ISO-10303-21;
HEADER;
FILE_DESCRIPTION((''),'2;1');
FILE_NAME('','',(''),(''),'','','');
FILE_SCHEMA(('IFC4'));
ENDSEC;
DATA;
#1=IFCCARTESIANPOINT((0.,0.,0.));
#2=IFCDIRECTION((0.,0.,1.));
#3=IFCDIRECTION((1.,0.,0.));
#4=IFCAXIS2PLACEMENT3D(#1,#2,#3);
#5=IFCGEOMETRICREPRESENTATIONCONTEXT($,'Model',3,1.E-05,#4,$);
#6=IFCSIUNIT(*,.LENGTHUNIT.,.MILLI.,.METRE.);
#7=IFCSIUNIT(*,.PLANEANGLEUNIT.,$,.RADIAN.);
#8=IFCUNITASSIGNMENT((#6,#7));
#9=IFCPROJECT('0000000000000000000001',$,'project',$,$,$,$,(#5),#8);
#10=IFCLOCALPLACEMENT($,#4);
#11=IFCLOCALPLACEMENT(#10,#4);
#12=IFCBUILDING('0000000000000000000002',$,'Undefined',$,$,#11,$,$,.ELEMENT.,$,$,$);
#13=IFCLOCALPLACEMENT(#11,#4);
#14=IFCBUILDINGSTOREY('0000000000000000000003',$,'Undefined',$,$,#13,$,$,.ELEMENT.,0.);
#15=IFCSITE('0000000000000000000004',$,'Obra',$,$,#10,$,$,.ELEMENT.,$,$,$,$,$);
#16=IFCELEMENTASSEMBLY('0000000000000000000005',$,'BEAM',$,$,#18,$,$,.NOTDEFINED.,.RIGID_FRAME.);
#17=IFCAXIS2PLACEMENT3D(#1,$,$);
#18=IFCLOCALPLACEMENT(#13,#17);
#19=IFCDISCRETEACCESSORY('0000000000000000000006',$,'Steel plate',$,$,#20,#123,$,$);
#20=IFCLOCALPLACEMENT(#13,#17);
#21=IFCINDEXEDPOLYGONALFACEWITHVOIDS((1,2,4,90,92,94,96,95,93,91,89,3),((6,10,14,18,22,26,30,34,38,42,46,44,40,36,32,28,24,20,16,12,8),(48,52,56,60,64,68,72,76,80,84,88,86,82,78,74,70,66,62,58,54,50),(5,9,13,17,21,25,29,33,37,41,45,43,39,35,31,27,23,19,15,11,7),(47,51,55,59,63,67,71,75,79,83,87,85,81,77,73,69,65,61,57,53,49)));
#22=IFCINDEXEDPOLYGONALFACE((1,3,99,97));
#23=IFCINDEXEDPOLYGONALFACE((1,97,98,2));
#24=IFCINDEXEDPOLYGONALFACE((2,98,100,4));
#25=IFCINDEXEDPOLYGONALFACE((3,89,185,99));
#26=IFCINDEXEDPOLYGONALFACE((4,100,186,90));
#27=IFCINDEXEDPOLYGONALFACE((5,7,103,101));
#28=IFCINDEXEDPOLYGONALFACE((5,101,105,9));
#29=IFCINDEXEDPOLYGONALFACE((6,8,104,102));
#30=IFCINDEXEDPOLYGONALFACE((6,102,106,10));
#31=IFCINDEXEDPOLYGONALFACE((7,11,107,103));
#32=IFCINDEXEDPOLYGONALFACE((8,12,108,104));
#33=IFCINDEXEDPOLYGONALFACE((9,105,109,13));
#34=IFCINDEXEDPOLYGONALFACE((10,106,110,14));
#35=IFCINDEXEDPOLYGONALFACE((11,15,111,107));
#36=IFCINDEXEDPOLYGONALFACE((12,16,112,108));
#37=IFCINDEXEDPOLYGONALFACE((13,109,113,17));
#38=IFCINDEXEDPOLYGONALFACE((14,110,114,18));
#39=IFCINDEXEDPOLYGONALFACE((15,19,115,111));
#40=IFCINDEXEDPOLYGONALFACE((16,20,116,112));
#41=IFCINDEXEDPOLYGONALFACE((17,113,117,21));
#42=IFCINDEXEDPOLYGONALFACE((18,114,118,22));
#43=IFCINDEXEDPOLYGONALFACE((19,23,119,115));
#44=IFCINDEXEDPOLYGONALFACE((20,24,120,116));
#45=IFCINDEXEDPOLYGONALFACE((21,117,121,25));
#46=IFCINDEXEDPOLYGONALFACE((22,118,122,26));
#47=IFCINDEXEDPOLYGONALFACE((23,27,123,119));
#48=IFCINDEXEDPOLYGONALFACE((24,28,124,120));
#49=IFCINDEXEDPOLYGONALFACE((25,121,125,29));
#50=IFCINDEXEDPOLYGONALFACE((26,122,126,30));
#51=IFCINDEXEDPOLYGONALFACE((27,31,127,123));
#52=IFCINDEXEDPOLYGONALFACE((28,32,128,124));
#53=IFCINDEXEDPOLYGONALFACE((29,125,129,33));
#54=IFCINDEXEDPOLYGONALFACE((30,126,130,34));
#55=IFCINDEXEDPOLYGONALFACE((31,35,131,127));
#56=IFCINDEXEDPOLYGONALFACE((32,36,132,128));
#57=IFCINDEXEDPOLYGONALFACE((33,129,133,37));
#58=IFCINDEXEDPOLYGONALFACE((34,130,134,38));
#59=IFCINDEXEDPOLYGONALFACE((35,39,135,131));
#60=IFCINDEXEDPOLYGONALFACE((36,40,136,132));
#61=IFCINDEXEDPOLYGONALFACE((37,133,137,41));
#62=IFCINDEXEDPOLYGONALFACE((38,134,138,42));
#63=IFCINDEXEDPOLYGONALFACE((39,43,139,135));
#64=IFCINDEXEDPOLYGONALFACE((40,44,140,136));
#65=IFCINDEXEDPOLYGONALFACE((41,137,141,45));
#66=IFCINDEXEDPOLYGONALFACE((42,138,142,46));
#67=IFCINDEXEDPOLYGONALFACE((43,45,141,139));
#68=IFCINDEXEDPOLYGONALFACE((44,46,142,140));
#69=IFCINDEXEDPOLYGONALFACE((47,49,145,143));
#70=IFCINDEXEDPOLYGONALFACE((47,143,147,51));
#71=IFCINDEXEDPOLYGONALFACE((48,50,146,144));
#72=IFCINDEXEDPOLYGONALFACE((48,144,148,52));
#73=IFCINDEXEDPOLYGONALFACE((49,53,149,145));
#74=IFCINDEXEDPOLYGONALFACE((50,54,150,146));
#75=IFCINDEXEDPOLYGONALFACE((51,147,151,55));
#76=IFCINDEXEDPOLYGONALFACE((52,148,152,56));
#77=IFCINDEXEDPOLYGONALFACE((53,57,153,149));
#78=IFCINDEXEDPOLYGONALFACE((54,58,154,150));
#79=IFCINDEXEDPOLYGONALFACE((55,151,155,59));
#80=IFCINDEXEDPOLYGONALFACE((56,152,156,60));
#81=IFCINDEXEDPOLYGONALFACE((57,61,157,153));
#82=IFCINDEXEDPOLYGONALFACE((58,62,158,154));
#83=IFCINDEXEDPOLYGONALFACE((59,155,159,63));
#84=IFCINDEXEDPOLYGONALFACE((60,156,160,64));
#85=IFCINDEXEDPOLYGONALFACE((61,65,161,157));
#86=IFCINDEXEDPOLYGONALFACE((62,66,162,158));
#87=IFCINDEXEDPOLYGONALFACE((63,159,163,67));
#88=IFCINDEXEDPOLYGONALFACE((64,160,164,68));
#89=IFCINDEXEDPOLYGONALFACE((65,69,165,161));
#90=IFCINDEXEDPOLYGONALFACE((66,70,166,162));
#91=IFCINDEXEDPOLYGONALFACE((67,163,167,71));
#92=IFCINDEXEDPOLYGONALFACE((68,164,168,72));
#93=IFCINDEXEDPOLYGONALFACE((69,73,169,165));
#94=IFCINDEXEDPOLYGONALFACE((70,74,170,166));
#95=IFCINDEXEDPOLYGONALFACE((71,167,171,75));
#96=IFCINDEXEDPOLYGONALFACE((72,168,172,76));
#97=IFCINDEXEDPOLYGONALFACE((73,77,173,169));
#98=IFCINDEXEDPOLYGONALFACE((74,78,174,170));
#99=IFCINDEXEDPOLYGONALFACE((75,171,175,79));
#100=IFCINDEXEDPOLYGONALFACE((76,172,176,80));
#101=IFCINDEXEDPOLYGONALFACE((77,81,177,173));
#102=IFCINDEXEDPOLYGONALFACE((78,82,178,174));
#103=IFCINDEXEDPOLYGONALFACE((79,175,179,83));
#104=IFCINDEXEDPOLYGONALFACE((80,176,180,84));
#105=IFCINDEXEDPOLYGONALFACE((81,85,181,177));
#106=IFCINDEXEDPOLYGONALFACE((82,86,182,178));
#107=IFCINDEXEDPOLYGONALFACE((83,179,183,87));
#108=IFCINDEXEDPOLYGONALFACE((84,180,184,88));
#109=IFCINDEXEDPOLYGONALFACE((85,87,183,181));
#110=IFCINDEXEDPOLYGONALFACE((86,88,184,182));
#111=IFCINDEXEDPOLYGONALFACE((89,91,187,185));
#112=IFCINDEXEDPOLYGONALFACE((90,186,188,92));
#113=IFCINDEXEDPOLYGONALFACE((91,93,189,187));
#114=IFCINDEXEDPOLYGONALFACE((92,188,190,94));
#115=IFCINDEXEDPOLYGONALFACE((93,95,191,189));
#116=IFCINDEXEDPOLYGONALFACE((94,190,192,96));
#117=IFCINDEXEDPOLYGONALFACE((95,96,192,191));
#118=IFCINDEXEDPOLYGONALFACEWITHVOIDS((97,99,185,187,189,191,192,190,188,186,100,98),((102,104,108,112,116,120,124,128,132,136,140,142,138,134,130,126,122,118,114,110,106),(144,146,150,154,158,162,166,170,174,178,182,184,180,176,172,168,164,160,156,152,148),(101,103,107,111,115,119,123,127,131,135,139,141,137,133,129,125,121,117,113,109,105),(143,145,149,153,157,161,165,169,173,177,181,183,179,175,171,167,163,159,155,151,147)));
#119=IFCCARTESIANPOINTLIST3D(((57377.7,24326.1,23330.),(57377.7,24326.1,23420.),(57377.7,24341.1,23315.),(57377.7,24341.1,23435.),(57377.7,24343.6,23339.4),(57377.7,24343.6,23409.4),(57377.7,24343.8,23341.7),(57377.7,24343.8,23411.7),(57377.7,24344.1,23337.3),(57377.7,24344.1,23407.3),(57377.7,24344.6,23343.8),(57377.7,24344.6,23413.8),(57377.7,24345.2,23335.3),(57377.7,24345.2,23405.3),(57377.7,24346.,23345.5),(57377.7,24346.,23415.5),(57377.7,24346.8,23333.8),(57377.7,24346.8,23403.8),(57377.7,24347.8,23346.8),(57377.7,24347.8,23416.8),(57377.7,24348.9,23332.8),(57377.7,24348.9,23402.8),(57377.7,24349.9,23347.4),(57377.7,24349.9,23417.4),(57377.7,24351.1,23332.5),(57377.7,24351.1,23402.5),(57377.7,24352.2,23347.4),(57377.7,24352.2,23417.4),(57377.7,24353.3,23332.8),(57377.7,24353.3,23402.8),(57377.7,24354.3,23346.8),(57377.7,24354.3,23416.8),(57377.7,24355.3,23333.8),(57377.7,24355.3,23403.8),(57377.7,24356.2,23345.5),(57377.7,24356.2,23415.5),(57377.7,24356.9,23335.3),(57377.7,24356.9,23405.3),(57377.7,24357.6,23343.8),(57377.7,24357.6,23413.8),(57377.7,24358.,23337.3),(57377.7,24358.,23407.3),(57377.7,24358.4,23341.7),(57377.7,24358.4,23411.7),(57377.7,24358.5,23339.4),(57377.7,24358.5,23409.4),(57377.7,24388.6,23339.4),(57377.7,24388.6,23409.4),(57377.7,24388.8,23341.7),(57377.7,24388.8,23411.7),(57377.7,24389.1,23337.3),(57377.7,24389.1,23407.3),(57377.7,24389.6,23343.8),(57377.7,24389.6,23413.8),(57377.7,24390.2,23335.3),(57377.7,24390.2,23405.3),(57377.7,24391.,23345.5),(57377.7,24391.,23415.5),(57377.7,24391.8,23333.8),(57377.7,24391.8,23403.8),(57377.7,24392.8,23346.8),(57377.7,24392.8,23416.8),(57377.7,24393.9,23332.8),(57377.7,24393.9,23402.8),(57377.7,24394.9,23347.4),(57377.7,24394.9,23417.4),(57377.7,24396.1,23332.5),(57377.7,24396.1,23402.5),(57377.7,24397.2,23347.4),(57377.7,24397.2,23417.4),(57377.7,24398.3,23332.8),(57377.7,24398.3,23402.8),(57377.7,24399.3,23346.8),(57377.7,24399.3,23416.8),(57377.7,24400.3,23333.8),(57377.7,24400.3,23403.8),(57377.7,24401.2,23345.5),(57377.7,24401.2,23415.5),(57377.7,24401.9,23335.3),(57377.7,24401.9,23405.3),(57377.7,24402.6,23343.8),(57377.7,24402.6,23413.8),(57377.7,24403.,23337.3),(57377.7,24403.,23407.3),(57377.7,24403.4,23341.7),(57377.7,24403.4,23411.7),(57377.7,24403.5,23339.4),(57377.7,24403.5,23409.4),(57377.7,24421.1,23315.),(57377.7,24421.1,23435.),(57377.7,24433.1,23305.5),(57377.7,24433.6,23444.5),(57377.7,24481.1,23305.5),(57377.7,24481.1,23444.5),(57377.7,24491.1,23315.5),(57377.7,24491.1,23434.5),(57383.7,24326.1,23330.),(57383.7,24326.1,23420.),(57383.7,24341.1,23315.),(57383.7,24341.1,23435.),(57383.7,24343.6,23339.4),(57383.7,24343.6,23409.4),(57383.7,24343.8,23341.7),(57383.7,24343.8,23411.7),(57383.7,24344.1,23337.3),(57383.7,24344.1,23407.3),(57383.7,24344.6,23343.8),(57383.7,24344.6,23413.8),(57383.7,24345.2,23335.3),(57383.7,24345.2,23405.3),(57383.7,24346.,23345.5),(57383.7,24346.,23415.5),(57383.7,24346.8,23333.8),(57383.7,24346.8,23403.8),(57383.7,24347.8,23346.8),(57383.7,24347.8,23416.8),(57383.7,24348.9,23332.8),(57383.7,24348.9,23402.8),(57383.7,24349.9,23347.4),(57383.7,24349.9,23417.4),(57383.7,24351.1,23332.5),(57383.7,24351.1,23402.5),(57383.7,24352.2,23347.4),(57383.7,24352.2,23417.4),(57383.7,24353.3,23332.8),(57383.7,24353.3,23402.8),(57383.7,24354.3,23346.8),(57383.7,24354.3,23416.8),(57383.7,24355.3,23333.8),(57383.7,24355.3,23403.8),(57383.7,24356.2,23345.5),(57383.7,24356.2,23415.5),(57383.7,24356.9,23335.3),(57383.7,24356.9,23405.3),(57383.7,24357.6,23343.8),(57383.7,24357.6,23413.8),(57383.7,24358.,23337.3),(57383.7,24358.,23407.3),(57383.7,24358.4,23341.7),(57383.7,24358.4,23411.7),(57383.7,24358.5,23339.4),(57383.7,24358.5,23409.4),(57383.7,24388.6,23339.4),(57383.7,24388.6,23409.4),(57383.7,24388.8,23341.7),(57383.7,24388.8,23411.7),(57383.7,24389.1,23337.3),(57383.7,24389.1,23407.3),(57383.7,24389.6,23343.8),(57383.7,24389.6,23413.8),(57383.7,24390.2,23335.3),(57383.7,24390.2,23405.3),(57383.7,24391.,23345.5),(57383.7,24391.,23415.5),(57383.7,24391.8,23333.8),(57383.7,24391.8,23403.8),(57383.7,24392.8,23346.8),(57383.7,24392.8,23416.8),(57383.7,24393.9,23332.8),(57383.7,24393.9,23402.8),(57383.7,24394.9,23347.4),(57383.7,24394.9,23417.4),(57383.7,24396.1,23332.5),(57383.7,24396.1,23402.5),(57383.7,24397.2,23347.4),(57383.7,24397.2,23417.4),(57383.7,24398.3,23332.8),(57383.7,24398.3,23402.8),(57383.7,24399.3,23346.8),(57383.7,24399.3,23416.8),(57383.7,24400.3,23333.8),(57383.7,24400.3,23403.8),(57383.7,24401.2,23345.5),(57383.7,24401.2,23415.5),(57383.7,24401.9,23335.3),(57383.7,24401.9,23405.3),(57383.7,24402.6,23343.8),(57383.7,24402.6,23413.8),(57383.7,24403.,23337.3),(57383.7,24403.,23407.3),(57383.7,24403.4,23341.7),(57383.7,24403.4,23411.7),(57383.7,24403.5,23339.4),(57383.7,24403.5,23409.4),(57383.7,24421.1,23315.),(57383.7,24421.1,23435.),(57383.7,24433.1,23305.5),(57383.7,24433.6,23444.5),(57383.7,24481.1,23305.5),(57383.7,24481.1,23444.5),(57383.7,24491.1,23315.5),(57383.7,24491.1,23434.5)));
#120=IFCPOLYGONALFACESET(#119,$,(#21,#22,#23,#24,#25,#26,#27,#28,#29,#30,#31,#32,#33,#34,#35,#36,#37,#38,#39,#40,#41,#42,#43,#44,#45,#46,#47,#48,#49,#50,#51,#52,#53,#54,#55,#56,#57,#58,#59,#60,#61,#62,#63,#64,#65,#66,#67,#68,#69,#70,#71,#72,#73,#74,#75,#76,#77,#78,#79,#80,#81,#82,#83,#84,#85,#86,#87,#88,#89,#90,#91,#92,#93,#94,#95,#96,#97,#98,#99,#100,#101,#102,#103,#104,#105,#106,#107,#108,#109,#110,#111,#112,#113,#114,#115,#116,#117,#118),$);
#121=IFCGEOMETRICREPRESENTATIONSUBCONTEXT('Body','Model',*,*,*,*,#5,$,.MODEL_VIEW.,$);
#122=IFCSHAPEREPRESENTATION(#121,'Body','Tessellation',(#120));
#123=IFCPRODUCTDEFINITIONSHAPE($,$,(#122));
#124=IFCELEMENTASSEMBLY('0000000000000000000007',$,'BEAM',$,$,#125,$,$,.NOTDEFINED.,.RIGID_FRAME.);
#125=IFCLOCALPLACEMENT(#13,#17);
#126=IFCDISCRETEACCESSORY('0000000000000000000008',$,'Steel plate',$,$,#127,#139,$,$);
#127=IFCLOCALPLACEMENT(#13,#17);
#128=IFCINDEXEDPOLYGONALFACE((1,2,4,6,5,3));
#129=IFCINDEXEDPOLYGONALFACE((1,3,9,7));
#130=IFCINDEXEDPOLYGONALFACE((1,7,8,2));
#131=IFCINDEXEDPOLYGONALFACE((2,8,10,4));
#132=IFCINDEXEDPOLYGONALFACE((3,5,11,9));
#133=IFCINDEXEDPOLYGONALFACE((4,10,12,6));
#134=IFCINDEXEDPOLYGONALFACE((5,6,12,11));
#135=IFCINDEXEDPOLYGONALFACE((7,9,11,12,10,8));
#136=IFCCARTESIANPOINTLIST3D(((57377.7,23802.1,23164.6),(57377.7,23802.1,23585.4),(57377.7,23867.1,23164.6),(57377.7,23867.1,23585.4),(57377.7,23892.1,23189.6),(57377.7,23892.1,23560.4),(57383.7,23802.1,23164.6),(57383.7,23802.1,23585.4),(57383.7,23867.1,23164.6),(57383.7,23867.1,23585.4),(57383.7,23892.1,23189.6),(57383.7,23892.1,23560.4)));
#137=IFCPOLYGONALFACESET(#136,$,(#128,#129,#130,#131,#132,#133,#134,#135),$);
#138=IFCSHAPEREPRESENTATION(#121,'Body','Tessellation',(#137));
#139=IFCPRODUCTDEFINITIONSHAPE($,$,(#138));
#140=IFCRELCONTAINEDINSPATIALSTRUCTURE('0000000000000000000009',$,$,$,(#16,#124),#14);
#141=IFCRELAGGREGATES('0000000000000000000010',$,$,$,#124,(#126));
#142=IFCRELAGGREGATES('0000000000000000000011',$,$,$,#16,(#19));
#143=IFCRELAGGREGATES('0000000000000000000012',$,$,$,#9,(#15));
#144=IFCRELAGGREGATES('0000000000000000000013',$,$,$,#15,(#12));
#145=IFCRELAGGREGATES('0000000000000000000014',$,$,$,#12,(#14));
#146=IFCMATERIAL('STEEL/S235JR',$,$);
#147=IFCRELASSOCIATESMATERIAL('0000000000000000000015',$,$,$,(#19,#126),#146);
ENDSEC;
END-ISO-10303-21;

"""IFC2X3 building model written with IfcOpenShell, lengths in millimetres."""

from ifc_helpers import new_model, si_unit, frame, origin_with_axes, origin_2d_with_axis, place, context, subcontext, project, spatial, polyline, circle, outline, extrude, source, transform, mapped, material, element, aggregate, save


model = new_model("IFC2X3")

# Units and contexts
model_context = context("Model", 3, precision=1e-05, world=origin_with_axes())
body_context = subcontext(model_context, "Body", "Model", "MODEL_VIEW")
ifc_project = project(units=[si_unit("LENGTHUNIT", "METRE", prefix="MILLI"), si_unit("PLANEANGLEUNIT", "RADIAN")], contexts=[model_context])

# Site, building, storey
site_placement = place(None, origin_with_axes())
site = spatial("IfcSite", under=ifc_project, at=site_placement, Name="Obra", CompositionType="ELEMENT")
building_placement = place(site_placement, origin_with_axes())
building = spatial("IfcBuilding", under=site, at=building_placement, Name="Undefined", CompositionType="ELEMENT")
storey_placement = place(building_placement, origin_with_axes())
storey = spatial("IfcBuildingStorey", under=building, at=storey_placement, Name="Undefined", CompositionType="ELEMENT", Elevation=0.0)

# Shared definitions
ifc_material_1 = material(Name="STEEL/S235JR")

# Element assembly, discrete accessory, opening
assembly_1_placement = place(storey_placement, origin_with_axes())
assembly_1 = element("IfcElementAssembly", 1, at=assembly_1_placement, inside=storey, Name="BEAM", AssemblyPlace="NOTDEFINED", PredefinedType="RIGID_FRAME")
shared_shape_1 = source(origin_with_axes(), body_context, "Body", "SweptSolid", [
    extrude(circle(Radius=7.5, at=origin_2d_with_axis()), frame((0.0, 2.4, 0.0), z_axis=(0.0, 1.0, 0.0), x_axis=(1.0, 0.0, 0.0)), (0.0, 0.0, 1.0), 6.2),
])
discrete_accessory_1_placement = place(assembly_1_placement, frame((57380.7, 24491.1, 23315.5), z_axis=(-1.0, 0.0, 0.0), x_axis=(0.0, -0.707107, -0.707107)))
discrete_accessory_1 = element("IfcDiscreteAccessory", 2, at=discrete_accessory_1_placement, material=ifc_material_1, Name="Steel plate", context=body_context, shape_type="SweptSolid", body=[
    extrude(outline(polyline([(0.0, 0.0), (14.1, 0.0), (48.1, 33.9), (49.9, 49.1), (106.4, 105.7), (106.4, 126.9), (42.8, 190.6), (21.6, 190.6), (-35.0, 134.0), (-50.6, 131.9), (-84.1, 98.3), (-84.1, 84.1), (0.0, 0.0)])), frame((0.0, 0.0, -3.0), z_axis=(0.0, 0.0, 1.0), x_axis=(1.0, 0.0, 0.0)), (0.0, 0.0, 1.0), 6.0),
])
opening_1_placement = place(assembly_1_placement, frame((57375.2, 24373.6, 23410.0), z_axis=(0.0, -1.0, 0.0), x_axis=(0.0, 0.0, -1.0)))
element("IfcOpeningElement", 3, at=opening_1_placement, cuts=discrete_accessory_1, ObjectType="Opening", context=body_context, shape_type="MappedRepresentation", body=[
    mapped(shared_shape_1, transform((0.0, 0.0, -22.5))),
    mapped(shared_shape_1, transform((70.0, 0.0, -22.5))),
    mapped(shared_shape_1, transform((0.0, 0.0, 22.5))),
    mapped(shared_shape_1, transform((70.0, 0.0, 22.5))),
])

# Element assembly, discrete accessory
assembly_2_placement = place(storey_placement, origin_with_axes())
assembly_2 = element("IfcElementAssembly", 4, at=assembly_2_placement, inside=storey, Name="BEAM", AssemblyPlace="NOTDEFINED", PredefinedType="RIGID_FRAME")
discrete_accessory_2_placement = place(assembly_2_placement, frame((57380.7, 23892.1, 23164.6), z_axis=(-1.0, 0.0, 0.0), x_axis=(0.0, -1.0, 0.0)))
discrete_accessory_2 = element("IfcDiscreteAccessory", 5, at=discrete_accessory_2_placement, material=ifc_material_1, Name="Steel plate", context=body_context, shape_type="SweptSolid", body=[
    extrude(outline(polyline([(0.0, 25.0), (25.0, 0.0), (90.0, 0.0), (90.0, 420.8), (25.0, 420.8), (0.0, 395.8), (0.0, 25.0)])), frame((0.0, 0.0, -3.0), z_axis=(0.0, 0.0, 1.0), x_axis=(1.0, 0.0, 0.0)), (0.0, 0.0, 1.0), 6.0),
])

aggregate(assembly_2, [discrete_accessory_2])
aggregate(assembly_1, [discrete_accessory_1])

save(model, "model.ifc")
